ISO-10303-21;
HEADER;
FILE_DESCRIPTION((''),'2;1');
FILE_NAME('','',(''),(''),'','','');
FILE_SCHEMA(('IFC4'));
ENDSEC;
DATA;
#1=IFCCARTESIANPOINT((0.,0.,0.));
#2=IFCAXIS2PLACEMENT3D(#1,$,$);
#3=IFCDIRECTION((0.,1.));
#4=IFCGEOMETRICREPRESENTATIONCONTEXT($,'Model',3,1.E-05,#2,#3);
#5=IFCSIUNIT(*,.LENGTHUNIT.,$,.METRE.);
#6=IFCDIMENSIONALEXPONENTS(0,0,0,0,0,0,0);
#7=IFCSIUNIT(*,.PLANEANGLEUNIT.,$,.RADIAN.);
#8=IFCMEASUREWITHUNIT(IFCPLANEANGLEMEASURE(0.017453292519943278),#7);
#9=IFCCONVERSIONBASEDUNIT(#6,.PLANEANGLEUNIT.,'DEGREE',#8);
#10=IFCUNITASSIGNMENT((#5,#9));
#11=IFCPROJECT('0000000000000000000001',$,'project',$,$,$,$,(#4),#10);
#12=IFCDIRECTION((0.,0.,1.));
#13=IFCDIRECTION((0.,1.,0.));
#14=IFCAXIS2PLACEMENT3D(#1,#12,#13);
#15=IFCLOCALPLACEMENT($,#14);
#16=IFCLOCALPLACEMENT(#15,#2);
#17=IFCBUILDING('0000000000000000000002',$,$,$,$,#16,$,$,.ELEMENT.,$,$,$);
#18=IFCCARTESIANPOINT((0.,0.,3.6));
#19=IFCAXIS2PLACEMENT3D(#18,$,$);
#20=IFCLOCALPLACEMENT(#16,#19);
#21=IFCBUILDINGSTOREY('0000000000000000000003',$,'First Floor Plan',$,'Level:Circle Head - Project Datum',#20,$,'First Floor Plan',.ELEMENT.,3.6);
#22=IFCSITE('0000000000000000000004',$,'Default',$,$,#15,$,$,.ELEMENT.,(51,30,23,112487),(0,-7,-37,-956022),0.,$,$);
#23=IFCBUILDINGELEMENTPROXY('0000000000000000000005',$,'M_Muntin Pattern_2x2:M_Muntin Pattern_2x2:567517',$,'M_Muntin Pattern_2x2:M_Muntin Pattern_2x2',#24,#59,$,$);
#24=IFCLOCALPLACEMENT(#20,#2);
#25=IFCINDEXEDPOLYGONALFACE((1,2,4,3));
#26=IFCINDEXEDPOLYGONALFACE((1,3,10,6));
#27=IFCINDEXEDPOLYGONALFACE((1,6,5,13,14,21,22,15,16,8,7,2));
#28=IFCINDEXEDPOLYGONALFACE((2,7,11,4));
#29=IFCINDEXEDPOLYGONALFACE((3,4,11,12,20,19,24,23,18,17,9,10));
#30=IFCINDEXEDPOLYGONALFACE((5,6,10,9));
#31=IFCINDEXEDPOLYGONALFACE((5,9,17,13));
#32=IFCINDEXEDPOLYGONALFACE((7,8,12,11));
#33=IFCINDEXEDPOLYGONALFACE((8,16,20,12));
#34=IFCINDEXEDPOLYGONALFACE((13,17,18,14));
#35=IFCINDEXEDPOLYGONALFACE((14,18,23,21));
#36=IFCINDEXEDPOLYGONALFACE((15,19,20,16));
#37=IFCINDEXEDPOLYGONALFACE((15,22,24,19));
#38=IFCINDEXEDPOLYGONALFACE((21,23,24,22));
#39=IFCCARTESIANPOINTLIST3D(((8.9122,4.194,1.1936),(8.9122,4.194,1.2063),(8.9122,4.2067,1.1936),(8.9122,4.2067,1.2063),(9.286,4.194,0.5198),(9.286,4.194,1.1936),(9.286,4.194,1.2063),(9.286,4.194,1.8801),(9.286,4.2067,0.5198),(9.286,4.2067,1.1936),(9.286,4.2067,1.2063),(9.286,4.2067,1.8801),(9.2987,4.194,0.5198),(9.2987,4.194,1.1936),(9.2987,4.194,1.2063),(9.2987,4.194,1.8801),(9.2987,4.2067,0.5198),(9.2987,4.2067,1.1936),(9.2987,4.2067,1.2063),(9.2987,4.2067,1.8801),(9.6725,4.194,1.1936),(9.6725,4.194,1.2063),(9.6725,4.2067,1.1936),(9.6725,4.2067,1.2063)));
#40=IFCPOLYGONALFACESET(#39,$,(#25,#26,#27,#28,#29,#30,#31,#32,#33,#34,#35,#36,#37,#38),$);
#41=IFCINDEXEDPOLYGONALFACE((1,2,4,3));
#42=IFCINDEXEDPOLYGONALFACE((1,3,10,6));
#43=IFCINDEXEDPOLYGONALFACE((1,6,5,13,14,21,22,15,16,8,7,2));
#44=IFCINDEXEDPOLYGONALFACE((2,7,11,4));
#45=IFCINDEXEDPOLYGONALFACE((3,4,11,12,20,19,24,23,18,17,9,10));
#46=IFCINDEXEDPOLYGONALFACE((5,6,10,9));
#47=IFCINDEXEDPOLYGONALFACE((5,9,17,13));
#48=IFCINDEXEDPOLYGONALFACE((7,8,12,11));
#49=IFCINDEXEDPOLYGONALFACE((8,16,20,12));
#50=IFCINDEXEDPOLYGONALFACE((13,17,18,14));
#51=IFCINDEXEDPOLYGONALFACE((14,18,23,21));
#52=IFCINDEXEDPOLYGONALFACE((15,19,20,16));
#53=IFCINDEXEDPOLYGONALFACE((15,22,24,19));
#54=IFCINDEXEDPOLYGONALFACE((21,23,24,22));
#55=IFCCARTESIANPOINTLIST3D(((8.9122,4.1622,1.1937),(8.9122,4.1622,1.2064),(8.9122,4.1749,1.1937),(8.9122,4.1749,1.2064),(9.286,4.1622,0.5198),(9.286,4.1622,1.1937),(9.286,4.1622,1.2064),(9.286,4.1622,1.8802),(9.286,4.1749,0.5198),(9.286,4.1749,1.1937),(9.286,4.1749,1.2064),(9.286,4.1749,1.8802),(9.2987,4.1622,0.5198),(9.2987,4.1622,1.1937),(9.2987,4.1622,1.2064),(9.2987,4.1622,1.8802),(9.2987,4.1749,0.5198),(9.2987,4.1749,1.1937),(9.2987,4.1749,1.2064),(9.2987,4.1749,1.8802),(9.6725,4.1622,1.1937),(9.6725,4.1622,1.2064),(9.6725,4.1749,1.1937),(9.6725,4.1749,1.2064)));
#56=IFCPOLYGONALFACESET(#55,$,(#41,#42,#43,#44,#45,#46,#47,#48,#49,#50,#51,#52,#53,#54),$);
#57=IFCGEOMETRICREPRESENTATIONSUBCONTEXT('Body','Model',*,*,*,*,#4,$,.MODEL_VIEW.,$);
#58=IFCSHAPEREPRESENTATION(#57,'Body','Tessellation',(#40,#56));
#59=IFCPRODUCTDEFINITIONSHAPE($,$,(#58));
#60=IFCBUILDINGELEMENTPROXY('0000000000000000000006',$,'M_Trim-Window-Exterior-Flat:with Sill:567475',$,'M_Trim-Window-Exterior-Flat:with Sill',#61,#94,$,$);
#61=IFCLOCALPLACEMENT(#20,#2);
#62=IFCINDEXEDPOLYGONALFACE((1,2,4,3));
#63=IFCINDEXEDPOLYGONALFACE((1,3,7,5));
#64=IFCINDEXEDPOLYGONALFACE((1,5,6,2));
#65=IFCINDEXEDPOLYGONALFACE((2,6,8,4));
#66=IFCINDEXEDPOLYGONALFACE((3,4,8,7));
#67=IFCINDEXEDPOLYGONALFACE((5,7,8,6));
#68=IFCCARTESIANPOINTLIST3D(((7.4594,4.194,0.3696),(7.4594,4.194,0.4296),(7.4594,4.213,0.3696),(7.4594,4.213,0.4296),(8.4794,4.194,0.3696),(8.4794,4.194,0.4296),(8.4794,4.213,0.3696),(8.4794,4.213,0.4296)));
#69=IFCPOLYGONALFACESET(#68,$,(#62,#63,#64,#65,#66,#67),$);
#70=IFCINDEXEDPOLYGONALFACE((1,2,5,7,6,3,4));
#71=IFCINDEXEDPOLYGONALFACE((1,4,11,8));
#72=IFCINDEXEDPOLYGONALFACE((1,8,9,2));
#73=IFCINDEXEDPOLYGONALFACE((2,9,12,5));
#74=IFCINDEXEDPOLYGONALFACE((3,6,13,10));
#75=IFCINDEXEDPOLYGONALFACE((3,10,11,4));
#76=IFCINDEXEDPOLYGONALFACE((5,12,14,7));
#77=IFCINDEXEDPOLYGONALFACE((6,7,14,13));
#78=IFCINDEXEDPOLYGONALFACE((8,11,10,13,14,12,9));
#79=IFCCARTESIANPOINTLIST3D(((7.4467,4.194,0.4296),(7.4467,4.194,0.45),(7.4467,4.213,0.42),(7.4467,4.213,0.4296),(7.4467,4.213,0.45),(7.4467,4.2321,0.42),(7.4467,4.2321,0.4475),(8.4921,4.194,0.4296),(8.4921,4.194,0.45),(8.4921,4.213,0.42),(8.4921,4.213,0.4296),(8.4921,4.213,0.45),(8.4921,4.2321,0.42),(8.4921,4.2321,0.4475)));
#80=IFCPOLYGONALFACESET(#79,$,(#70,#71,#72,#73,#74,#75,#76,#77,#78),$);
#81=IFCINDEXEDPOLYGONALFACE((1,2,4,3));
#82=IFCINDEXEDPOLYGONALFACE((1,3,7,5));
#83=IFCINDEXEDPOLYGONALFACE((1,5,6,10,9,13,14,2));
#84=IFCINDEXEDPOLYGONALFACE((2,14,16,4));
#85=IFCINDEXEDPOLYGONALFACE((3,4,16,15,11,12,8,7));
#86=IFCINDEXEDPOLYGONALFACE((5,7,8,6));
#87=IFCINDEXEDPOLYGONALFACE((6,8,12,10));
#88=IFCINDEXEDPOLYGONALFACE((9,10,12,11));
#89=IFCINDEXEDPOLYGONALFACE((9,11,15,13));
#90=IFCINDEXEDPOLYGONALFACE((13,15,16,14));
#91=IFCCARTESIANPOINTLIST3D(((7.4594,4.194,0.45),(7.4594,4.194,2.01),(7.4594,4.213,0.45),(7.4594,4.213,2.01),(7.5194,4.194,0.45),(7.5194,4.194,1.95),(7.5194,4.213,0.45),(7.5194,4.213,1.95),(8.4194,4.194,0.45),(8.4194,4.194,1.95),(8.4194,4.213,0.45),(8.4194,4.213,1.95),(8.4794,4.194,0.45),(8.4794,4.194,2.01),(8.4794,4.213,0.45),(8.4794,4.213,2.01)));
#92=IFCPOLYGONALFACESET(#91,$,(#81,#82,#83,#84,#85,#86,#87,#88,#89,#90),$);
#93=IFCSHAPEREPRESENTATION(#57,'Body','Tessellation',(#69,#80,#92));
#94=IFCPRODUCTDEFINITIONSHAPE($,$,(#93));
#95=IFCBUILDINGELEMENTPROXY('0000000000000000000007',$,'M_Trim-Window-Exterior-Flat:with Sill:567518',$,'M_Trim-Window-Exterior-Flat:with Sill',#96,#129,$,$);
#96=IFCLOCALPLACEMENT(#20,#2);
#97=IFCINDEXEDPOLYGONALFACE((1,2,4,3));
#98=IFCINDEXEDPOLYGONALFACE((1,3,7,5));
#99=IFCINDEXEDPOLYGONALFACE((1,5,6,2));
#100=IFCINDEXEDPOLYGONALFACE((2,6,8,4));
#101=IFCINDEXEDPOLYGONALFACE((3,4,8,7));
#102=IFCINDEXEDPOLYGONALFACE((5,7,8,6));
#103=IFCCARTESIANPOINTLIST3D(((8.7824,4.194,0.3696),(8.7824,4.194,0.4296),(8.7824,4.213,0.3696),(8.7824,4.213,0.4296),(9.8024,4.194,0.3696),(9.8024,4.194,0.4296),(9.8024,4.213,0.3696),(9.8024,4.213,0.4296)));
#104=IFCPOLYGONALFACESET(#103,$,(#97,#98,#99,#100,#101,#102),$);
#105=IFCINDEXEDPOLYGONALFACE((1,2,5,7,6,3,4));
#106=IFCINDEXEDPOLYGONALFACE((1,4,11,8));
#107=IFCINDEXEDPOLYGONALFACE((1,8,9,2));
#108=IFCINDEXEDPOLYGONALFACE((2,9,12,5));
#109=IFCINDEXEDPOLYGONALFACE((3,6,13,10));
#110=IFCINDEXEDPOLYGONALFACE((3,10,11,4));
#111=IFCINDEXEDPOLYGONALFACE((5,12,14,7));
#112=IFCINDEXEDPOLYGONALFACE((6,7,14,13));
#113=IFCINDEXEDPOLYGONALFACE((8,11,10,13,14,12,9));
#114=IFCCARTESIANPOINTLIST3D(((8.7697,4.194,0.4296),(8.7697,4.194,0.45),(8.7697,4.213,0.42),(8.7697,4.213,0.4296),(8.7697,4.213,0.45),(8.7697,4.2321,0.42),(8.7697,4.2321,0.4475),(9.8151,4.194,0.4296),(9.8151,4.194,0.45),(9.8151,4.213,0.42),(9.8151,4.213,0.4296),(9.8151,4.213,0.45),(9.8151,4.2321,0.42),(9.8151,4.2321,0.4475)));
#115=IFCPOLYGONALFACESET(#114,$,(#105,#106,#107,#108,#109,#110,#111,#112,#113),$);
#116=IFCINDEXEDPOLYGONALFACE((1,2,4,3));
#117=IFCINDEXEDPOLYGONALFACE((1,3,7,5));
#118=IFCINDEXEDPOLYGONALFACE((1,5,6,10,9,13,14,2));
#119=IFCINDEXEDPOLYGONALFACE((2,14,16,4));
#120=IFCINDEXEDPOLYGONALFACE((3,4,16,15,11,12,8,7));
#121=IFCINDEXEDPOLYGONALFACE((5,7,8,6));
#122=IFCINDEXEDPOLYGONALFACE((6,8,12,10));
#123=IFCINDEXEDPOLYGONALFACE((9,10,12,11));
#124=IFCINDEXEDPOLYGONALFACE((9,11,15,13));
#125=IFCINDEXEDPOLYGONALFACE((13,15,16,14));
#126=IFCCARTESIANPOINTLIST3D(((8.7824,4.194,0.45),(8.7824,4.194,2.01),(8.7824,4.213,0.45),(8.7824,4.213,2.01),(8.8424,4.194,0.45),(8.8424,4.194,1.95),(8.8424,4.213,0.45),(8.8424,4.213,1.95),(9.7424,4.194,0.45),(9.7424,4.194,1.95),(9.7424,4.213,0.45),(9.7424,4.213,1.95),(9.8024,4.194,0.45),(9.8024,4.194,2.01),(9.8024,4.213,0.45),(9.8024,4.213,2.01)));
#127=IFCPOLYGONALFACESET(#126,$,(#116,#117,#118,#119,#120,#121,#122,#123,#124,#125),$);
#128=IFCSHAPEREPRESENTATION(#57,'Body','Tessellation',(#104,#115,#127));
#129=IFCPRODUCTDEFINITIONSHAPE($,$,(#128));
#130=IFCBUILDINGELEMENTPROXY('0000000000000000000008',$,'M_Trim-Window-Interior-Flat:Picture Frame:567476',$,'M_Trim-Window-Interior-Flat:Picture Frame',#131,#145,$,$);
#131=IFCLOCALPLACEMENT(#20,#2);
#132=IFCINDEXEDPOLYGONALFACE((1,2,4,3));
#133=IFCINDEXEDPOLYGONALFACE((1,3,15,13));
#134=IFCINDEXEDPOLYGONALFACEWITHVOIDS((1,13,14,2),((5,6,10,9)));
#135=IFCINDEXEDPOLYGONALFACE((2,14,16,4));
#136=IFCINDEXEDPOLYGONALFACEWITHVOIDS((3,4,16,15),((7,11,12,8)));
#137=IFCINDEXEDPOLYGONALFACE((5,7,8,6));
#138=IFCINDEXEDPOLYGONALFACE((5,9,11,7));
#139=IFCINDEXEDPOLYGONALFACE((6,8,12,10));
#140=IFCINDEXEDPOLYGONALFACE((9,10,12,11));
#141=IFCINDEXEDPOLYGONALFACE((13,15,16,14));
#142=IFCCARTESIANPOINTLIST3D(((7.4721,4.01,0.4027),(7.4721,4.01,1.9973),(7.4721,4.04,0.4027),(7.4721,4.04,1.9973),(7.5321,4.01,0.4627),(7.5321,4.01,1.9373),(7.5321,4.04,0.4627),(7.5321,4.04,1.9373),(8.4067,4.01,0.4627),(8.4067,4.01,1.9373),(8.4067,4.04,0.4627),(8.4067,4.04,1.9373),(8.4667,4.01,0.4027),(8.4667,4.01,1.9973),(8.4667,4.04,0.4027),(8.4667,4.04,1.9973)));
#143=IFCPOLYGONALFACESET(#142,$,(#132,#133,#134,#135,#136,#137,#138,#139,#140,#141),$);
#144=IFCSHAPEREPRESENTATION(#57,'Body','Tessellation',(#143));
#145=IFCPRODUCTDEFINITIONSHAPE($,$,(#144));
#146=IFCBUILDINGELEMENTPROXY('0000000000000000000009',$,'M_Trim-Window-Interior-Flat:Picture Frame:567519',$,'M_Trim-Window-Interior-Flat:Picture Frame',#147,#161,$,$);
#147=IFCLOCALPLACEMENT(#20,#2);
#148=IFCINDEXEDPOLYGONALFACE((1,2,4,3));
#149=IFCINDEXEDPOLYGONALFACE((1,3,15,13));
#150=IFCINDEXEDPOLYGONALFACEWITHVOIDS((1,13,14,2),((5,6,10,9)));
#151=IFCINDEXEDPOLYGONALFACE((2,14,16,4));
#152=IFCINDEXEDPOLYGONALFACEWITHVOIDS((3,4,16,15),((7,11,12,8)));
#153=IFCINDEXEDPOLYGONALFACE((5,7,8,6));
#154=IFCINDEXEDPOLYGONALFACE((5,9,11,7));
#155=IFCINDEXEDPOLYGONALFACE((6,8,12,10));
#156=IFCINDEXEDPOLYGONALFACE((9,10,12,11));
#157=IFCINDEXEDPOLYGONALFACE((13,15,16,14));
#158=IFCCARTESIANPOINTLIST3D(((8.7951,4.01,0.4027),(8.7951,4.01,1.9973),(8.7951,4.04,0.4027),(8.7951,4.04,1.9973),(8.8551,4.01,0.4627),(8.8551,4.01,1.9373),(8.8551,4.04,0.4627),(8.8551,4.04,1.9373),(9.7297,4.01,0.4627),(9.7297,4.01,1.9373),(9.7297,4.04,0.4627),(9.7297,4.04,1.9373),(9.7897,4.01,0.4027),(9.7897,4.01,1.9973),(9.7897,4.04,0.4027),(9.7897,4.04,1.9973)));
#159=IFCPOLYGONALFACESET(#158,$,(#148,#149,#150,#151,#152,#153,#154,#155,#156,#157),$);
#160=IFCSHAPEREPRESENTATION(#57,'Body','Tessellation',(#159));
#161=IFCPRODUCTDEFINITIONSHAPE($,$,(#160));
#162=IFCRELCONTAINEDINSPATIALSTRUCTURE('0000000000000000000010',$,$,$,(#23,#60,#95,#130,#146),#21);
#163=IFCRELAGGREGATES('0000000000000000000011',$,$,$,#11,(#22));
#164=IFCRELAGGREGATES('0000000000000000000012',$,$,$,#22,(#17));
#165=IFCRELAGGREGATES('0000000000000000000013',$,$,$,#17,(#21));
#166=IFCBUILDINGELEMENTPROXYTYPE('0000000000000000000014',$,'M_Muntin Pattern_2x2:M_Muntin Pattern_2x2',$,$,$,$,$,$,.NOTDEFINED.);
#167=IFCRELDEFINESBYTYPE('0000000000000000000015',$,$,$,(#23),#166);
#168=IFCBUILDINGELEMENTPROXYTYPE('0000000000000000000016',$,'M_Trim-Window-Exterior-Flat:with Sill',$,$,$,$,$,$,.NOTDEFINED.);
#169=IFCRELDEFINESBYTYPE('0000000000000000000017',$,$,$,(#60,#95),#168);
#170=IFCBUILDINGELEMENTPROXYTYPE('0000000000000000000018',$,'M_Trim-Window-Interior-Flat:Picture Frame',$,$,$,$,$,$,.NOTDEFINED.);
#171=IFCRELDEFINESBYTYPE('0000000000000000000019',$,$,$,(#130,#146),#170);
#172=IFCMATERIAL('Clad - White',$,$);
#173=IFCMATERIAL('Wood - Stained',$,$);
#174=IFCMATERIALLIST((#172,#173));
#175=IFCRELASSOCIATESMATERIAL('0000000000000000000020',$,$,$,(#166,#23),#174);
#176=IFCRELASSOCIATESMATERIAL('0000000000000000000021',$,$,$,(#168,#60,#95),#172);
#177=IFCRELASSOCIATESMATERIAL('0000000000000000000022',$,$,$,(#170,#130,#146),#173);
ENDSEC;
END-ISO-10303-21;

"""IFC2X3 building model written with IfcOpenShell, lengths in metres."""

from ifc_helpers import new_model, entity, si_unit, converted_unit, direction, frame, frame_2d, origin, place, context, subcontext, project, spatial, polyline, rectangle, outline, extrude, source, transform, mapped, material, material_list, type_object, type_shapes, element, save


model = new_model("IFC2X3")

# Units and contexts
model_context = context("Model", 3, precision=1e-05, world=origin(), true_north=direction((0.0, 1.0)))
body_context = subcontext(model_context, "Body", "Model", "MODEL_VIEW")
ifc_project = project(units=[si_unit("LENGTHUNIT", "METRE"), converted_unit("PLANEANGLEUNIT", "DEGREE", entity("IfcPlaneAngleMeasure", 0.017453292519943278), si_unit("PLANEANGLEUNIT", "RADIAN"), dimensions=[0, 0, 0, 0, 0, 0, 0])], contexts=[model_context])

# Site, building, storey
site_placement = place(None, frame((0.0, 0.0, 0.0), z_axis=(0.0, 0.0, 1.0), x_axis=(0.0, 1.0, 0.0)))
site = spatial("IfcSite", under=ifc_project, at=site_placement, Name="Default", CompositionType="ELEMENT", RefLatitude=(51, 30, 23, 112487), RefLongitude=(0, -7, -37, -956022), RefElevation=0.0)
building_placement = place(site_placement, origin())
building = spatial("IfcBuilding", under=site, at=building_placement, CompositionType="ELEMENT")
storey_placement = place(building_placement, frame((0.0, 0.0, 3.6)))
storey = spatial("IfcBuildingStorey", under=building, at=storey_placement, Name="First Floor Plan", ObjectType="Level:Circle Head - Project Datum", LongName="First Floor Plan", CompositionType="ELEMENT", Elevation=3.6)

# Building element proxies
ifc_material_1 = material(Name="Clad - White")
ifc_material_2 = material(Name="Wood - Stained")
ifc_material_list = material_list([ifc_material_1, ifc_material_2])
building_element_proxy_type_1 = type_object("IfcBuildingElementProxyType", Name="M_Muntin Pattern_2x2:M_Muntin Pattern_2x2", PredefinedType="NOTDEFINED", material=ifc_material_list)
shared_shape_1 = source(origin(), body_context, "Body", "SweptSolid", [
    extrude(outline(polyline([(0.0064, -0.0064), (0.6801, -0.0064), (0.6801, 0.0063), (0.0064, 0.0063), (0.0064, 0.3802), (-0.0063, 0.3802), (-0.0063, 0.0063), (-0.6802, 0.0063), (-0.6802, -0.0064), (-0.0063, -0.0064), (-0.0063, -0.3801), (0.0064, -0.3801), (0.0064, -0.0064)])), frame((0.0, 0.0095, 0.6801), z_axis=(0.0, 1.0, 0.0), x_axis=(0.0, 0.0, 1.0)), (0.0, 0.0, 1.0), 0.0127),
    extrude(outline(polyline([(0.0064, -0.0064), (0.6802, -0.0064), (0.6802, 0.0063), (0.0064, 0.0063), (0.0064, 0.3802), (-0.0063, 0.3802), (-0.0063, 0.0063), (-0.6802, 0.0063), (-0.6802, -0.0064), (-0.0063, -0.0064), (-0.0063, -0.3801), (0.0064, -0.3801), (0.0064, -0.0064)])), frame((0.0, -0.0222, 0.6802), z_axis=(0.0, 1.0, 0.0), x_axis=(0.0, 0.0, 1.0)), (0.0, 0.0, 1.0), 0.0127),
])
type_shapes(building_element_proxy_type_1, [shared_shape_1])
for number, where, name in (
    (1, (9.2924, 4.1845, 0.5198), "M_Muntin Pattern_2x2:M_Muntin Pattern_2x2:567517"),
):
    element("IfcBuildingElementProxy", number, at=place(storey_placement, frame(where)), inside=storey, type_object=building_element_proxy_type_1, material=ifc_material_list, Name=name, ObjectType="M_Muntin Pattern_2x2:M_Muntin Pattern_2x2", context=body_context, shape_type="MappedRepresentation", body=[
        mapped(shared_shape_1, transform((0.0, 0.0, 0.0), scale=1.0)),
    ])
building_element_proxy_type_2 = type_object("IfcBuildingElementProxyType", Name="M_Trim-Window-Exterior-Flat:with Sill", PredefinedType="NOTDEFINED", material=ifc_material_1)
shared_shape_2 = source(origin(), body_context, "Body", "SweptSolid", [
    extrude(rectangle(XDim=1.02, YDim=0.06, at=frame_2d((0.0, 0.0), x_axis=(1.0, 0.0))), frame((0.0, -1.5504, 0.0), z_axis=(0.0, 0.0, 1.0), x_axis=(-1.0, 0.0, 0.0)), (0.0, 0.0, 1.0), 0.019),
    extrude(outline(polyline([(-0.019, -0.0152), (0.0, -0.0152), (0.0, -0.0057), (0.019, -0.0057), (0.019, 0.0148), (0.0, 0.0148), (-0.019, 0.0123), (-0.019, -0.0152)])), frame((-0.5227, -1.5148, 0.019), z_axis=(1.0, 0.0, 0.0), x_axis=(0.0, 0.0, -1.0)), (0.0, 0.0, 1.0), 1.0454),
    extrude(outline(polyline([(-0.795, -0.51), (0.765, -0.51), (0.765, -0.45), (-0.735, -0.45), (-0.735, 0.45), (0.765, 0.45), (0.765, 0.51), (-0.795, 0.51), (-0.795, -0.51)])), frame((0.0, -0.735, 0.0), z_axis=(0.0, 0.0, 1.0), x_axis=(0.0, -1.0, 0.0)), (0.0, 0.0, 1.0), 0.019),
])
type_shapes(building_element_proxy_type_2, [shared_shape_2])
for number, where, z_axis, x_axis, name in (
    (2, (7.9694, 4.194, 1.95), (0.0, 1.0, 0.0), (-1.0, 0.0, 0.0), "M_Trim-Window-Exterior-Flat:with Sill:567475"),
    (3, (9.2924, 4.194, 1.95), (0.0, 1.0, 0.0), (-1.0, 0.0, 0.0), "M_Trim-Window-Exterior-Flat:with Sill:567518"),
):
    element("IfcBuildingElementProxy", number, at=place(storey_placement, frame(where, z_axis=z_axis, x_axis=x_axis)), inside=storey, type_object=building_element_proxy_type_2, material=ifc_material_1, Name=name, ObjectType="M_Trim-Window-Exterior-Flat:with Sill", context=body_context, shape_type="MappedRepresentation", body=[
        mapped(shared_shape_2, transform((0.0, 0.0, 0.0), scale=1.0)),
    ])
building_element_proxy_type_3 = type_object("IfcBuildingElementProxyType", Name="M_Trim-Window-Interior-Flat:Picture Frame", PredefinedType="NOTDEFINED", material=ifc_material_2)
shared_shape_3 = source(origin(), body_context, "Body", "SweptSolid", [
    extrude(outline(polyline([(-0.4973, -0.7973), (0.4973, -0.7973), (0.4973, 0.7973), (-0.4973, 0.7973), (-0.4973, -0.7973)]), holes=[polyline([(-0.4373, -0.7373), (-0.4373, 0.7373), (0.4373, 0.7373), (0.4373, -0.7373), (-0.4373, -0.7373)])]), frame((0.0, -0.75, 0.0), z_axis=(0.0, 0.0, 1.0), x_axis=(-1.0, 0.0, 0.0)), (0.0, 0.0, 1.0), 0.03),
])
type_shapes(building_element_proxy_type_3, [shared_shape_3])
for number, where, z_axis, x_axis, name in (
    (4, (7.9694, 4.04, 1.95), (0.0, -1.0, 0.0), (1.0, 0.0, 0.0), "M_Trim-Window-Interior-Flat:Picture Frame:567476"),
    (5, (9.2924, 4.04, 1.95), (0.0, -1.0, 0.0), (1.0, 0.0, 0.0), "M_Trim-Window-Interior-Flat:Picture Frame:567519"),
):
    element("IfcBuildingElementProxy", number, at=place(storey_placement, frame(where, z_axis=z_axis, x_axis=x_axis)), inside=storey, type_object=building_element_proxy_type_3, material=ifc_material_2, Name=name, ObjectType="M_Trim-Window-Interior-Flat:Picture Frame", context=body_context, shape_type="MappedRepresentation", body=[
        mapped(shared_shape_3, transform((0.0, 0.0, 0.0), scale=1.0)),
    ])

save(model, "model.ifc")
